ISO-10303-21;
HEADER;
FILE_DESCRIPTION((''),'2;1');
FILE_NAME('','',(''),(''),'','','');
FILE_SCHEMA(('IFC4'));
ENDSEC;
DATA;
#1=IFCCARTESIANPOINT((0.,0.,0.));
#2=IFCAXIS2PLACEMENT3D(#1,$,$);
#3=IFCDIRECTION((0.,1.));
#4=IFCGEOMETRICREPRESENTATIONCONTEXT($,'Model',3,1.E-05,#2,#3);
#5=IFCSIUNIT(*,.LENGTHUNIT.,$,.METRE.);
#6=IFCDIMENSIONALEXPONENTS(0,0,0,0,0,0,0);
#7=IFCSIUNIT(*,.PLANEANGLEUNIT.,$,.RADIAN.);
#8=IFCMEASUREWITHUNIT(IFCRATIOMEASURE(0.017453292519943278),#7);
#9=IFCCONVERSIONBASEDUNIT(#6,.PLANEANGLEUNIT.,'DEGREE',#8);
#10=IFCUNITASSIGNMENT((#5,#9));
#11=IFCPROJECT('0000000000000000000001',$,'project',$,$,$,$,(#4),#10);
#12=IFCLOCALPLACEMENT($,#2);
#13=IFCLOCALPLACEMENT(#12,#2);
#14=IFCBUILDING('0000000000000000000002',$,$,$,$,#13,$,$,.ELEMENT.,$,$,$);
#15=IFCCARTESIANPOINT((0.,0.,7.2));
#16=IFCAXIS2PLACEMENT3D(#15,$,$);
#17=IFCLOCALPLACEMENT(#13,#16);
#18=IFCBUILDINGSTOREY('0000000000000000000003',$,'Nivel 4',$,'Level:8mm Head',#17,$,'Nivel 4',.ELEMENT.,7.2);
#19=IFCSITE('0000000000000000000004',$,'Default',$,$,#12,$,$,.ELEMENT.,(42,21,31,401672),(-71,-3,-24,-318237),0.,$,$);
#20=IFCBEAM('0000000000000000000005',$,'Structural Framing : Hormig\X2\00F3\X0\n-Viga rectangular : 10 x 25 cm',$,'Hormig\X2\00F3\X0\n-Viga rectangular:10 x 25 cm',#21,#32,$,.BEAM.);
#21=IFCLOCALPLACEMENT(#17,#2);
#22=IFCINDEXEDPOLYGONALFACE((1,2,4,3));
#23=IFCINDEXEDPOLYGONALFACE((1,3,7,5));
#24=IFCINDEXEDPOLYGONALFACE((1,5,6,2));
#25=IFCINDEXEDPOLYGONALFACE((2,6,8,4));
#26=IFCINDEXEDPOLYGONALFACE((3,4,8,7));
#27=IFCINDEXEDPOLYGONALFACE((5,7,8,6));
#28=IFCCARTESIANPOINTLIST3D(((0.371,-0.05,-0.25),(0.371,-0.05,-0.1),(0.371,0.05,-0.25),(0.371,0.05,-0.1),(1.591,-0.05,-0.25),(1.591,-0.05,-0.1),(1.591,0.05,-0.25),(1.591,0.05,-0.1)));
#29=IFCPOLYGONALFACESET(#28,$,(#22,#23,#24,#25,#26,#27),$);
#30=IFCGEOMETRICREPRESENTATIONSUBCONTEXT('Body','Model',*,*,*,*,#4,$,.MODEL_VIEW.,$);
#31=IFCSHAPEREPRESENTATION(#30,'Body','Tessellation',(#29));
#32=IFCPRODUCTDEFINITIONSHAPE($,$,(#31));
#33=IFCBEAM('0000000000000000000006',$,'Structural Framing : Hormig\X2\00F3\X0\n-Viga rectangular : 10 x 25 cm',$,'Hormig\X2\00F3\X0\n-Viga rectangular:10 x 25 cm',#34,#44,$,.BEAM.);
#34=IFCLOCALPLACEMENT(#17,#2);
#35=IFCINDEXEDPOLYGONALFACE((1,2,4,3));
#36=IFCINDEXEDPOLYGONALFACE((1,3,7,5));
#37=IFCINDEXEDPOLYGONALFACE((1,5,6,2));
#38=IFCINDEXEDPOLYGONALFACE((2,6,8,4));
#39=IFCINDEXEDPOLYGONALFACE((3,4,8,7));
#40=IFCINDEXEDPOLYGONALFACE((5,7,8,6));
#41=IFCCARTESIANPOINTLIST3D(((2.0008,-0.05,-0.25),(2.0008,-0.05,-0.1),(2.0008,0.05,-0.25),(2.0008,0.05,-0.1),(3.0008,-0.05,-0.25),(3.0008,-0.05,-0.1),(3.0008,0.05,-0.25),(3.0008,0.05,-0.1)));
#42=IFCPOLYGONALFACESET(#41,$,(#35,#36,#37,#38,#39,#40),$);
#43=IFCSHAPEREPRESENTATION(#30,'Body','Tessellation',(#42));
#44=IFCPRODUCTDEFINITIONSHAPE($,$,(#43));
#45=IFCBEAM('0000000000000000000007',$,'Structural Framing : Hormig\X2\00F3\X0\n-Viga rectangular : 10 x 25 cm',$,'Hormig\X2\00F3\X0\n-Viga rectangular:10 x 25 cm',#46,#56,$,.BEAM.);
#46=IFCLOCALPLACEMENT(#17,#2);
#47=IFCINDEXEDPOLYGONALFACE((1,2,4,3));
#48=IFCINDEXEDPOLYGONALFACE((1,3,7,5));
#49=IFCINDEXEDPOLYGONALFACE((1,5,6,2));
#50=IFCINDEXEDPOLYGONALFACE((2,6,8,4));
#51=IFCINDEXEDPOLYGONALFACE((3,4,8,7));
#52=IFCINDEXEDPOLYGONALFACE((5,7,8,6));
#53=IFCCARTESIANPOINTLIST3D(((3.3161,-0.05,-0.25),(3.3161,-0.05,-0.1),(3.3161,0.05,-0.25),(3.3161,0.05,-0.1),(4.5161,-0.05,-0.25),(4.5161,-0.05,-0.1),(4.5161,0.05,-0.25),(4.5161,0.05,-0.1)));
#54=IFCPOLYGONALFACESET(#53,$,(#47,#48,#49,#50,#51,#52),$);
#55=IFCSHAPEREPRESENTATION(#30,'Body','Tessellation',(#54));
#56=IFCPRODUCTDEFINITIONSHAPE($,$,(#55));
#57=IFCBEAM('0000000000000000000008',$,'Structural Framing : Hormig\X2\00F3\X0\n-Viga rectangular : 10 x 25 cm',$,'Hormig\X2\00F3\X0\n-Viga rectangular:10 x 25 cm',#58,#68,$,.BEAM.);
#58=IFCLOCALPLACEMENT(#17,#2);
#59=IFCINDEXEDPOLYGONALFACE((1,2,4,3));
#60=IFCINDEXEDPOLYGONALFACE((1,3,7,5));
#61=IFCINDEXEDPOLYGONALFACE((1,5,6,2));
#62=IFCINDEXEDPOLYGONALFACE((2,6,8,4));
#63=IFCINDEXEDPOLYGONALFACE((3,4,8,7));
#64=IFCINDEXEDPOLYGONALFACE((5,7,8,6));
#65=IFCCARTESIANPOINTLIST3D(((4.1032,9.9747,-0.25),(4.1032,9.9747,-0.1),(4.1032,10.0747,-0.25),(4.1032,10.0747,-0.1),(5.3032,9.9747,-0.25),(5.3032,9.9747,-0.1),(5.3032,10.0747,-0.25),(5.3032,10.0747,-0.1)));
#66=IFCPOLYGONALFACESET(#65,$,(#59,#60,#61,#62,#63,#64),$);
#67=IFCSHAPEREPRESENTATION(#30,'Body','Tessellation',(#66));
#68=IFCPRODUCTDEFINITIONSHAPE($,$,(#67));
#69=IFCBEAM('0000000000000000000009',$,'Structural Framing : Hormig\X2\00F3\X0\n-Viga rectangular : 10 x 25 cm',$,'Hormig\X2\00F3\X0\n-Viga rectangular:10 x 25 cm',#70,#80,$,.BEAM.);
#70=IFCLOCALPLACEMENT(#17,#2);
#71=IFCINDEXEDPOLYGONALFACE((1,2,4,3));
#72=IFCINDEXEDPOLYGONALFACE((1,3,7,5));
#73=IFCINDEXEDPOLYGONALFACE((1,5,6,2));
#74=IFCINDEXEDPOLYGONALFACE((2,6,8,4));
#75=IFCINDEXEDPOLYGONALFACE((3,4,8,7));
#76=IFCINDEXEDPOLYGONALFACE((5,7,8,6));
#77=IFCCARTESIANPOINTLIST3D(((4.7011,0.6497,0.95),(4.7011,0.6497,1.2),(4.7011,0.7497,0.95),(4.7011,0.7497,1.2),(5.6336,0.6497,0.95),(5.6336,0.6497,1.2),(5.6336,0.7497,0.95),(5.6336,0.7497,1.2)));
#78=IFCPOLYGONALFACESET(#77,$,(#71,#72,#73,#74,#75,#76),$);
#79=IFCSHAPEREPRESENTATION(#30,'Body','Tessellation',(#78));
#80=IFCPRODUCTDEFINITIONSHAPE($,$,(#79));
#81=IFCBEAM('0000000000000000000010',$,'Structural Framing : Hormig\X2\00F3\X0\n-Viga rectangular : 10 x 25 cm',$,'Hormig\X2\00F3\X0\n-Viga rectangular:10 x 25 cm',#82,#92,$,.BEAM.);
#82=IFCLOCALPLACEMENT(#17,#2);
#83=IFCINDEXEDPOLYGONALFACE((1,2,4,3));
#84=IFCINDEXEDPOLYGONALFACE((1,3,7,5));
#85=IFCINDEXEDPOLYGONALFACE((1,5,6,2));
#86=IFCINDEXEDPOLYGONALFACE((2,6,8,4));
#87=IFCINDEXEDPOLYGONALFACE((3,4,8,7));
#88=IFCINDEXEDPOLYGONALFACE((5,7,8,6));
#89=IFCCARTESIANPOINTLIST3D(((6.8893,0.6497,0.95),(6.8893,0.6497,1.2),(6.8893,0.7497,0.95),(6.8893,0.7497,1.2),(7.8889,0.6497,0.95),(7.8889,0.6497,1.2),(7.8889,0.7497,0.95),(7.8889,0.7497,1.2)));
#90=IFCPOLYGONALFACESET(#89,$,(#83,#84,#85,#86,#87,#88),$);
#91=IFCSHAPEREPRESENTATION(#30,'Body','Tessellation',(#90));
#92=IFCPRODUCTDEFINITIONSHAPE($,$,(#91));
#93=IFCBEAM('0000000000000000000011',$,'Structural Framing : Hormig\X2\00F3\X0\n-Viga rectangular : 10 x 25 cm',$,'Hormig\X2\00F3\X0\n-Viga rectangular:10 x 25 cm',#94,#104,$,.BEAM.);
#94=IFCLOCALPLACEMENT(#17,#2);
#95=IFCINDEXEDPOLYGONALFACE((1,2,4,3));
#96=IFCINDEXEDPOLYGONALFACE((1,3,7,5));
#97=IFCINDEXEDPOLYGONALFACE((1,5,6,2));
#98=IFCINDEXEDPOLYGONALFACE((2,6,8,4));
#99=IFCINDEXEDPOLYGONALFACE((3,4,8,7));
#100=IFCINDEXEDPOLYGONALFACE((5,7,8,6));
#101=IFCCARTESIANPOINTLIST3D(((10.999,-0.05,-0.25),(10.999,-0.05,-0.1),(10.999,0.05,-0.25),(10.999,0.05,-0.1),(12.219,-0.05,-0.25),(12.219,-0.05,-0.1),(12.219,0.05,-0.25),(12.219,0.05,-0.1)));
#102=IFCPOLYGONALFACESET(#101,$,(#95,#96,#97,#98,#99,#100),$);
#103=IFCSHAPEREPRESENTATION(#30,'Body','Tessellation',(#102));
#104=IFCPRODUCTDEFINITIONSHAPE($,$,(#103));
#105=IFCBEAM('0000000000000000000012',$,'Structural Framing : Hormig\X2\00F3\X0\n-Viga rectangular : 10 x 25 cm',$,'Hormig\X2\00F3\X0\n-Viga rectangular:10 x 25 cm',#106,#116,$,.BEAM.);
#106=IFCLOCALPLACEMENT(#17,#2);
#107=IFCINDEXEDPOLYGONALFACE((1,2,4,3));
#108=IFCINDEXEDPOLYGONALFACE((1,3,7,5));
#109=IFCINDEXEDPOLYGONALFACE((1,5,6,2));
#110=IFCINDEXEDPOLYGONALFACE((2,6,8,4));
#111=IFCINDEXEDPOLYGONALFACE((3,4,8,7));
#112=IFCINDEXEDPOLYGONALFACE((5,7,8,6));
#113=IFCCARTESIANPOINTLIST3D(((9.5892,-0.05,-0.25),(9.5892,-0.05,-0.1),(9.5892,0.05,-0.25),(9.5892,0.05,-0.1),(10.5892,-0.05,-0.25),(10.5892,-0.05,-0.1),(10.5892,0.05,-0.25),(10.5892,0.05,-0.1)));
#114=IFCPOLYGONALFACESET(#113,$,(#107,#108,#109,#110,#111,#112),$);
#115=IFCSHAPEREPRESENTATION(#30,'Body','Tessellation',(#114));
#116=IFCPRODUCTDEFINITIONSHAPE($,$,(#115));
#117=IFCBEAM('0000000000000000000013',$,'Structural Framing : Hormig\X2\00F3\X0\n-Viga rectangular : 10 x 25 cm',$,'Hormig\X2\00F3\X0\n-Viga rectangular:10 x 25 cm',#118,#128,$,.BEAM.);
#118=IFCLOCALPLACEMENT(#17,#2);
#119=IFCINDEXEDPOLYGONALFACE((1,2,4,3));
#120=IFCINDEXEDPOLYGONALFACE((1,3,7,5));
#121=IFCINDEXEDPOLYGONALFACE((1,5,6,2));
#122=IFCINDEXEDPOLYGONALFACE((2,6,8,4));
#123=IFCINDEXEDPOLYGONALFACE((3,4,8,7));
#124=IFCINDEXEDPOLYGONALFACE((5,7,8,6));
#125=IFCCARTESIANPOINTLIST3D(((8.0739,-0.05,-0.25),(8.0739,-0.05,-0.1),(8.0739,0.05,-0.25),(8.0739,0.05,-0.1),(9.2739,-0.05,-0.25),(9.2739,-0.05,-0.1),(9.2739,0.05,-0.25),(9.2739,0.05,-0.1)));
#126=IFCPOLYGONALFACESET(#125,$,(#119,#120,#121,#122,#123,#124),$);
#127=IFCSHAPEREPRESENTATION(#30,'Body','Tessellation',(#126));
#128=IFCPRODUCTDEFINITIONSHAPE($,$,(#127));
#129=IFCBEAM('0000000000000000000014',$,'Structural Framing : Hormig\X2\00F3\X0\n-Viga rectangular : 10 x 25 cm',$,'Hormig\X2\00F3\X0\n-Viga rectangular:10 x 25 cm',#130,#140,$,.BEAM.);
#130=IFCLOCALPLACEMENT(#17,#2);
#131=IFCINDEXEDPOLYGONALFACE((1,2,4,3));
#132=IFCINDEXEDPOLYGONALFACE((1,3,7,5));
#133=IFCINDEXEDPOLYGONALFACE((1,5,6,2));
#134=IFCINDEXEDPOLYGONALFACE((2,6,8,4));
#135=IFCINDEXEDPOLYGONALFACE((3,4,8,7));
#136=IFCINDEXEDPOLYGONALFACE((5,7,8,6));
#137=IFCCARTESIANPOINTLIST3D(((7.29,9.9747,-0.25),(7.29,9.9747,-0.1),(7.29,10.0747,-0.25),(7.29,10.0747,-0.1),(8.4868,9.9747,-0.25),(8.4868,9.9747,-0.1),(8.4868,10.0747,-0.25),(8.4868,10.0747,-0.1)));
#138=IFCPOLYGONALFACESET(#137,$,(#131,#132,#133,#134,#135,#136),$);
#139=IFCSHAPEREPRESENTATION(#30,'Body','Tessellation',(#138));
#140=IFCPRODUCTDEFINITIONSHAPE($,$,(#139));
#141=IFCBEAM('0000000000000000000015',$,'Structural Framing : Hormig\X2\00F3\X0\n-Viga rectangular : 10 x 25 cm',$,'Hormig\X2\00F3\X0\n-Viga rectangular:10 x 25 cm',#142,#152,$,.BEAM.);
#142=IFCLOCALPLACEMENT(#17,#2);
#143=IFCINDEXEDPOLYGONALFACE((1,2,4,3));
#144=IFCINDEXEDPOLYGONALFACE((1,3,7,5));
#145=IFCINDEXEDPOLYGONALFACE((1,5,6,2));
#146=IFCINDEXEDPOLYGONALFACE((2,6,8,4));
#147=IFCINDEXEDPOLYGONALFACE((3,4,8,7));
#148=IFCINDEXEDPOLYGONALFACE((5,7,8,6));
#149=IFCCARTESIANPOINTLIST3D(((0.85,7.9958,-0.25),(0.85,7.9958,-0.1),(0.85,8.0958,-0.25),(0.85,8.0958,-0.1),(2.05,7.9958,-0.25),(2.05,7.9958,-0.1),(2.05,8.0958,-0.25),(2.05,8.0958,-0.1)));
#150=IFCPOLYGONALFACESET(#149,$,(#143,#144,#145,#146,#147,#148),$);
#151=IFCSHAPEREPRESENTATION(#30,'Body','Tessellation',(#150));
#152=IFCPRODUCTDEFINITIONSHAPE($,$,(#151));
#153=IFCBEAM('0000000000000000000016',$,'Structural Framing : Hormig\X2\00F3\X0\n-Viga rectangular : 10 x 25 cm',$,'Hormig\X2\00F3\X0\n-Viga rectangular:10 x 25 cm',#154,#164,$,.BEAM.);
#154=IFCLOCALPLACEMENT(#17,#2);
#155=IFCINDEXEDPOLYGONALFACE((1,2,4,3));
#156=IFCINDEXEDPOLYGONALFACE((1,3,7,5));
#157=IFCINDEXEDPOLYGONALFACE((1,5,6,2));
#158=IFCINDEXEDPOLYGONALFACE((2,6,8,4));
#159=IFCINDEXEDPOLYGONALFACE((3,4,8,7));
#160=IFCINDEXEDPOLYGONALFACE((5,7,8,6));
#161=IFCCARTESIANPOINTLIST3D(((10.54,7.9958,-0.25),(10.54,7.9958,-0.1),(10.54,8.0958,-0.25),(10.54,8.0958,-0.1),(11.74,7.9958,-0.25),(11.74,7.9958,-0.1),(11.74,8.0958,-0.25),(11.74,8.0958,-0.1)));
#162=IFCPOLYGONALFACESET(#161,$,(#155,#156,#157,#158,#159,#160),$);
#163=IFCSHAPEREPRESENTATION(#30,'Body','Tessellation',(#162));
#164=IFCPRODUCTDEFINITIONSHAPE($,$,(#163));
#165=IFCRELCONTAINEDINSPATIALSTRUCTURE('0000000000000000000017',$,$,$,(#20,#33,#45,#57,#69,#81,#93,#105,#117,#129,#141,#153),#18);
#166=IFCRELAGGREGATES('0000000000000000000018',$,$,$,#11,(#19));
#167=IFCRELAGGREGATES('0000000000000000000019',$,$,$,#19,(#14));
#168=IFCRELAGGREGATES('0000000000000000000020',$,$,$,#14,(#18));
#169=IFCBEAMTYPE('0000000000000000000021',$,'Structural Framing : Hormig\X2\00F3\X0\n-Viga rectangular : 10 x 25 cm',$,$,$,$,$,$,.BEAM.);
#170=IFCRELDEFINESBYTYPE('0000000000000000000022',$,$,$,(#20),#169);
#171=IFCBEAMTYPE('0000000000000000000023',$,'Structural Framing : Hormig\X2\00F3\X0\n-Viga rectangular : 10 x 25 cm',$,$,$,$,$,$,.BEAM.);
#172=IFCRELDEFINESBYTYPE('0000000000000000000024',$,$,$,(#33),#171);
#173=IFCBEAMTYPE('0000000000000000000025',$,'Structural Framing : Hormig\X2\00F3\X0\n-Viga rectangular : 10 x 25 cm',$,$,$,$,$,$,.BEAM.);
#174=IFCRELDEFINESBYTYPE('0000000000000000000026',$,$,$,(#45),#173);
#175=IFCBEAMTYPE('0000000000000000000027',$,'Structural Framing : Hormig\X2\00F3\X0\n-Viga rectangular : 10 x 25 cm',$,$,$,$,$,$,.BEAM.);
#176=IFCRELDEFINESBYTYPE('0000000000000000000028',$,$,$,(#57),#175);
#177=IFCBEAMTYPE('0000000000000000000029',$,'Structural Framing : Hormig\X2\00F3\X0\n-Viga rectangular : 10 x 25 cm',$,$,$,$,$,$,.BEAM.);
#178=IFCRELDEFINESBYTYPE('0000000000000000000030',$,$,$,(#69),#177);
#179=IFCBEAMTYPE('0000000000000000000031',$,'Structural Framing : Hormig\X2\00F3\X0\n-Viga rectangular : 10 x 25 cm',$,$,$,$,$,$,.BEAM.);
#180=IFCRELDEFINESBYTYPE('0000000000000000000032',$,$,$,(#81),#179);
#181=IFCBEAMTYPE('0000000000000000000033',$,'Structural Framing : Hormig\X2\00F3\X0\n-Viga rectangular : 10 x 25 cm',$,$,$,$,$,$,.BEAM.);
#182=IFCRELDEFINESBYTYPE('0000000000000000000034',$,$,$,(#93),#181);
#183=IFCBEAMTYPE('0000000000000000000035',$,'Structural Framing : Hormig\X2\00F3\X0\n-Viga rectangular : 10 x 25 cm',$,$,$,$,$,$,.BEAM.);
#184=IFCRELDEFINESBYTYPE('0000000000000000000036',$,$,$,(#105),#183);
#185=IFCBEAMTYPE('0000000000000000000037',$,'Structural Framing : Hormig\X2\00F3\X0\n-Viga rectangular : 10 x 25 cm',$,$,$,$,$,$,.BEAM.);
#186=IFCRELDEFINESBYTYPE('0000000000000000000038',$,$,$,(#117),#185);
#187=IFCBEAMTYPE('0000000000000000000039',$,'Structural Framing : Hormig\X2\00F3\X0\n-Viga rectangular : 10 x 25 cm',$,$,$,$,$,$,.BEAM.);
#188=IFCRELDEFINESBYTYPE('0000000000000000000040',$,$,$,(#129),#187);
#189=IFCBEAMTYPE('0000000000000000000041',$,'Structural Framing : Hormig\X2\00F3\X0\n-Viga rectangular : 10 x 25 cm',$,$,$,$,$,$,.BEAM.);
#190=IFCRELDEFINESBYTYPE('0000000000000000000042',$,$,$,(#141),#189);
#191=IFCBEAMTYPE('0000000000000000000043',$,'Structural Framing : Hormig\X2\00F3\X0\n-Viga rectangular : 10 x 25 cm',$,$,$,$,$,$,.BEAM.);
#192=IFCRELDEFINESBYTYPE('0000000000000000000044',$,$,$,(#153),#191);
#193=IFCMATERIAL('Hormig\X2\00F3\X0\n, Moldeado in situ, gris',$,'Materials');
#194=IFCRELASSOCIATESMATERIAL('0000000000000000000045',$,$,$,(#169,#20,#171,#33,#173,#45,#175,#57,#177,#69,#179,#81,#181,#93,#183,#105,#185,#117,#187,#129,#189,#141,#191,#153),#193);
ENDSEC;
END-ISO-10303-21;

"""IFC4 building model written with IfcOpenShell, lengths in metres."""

from ifc_helpers import new_model, entity, si_unit, converted_unit, direction, frame, origin, place, context, subcontext, project, spatial, indexed_curve, outline, extrude, source, transform, mapped, material, type_object, type_shapes, element, save


model = new_model("IFC4")

# Units and contexts
model_context = context("Model", 3, precision=1e-05, world=origin(), true_north=direction((0.0, 1.0)))
body_context = subcontext(model_context, "Body", "Model", "MODEL_VIEW")
ifc_project = project(units=[si_unit("LENGTHUNIT", "METRE"), converted_unit("PLANEANGLEUNIT", "DEGREE", entity("IfcRatioMeasure", 0.017453292519943278), si_unit("PLANEANGLEUNIT", "RADIAN"), dimensions=[0, 0, 0, 0, 0, 0, 0])], contexts=[model_context])

# Site, building, storey
site_placement = place(None, origin())
site = spatial("IfcSite", under=ifc_project, at=site_placement, Name="Default", CompositionType="ELEMENT", RefLatitude=(42, 21, 31, 401672), RefLongitude=(-71, -3, -24, -318237), RefElevation=0.0)
building_placement = place(site_placement, origin())
building = spatial("IfcBuilding", under=site, at=building_placement, CompositionType="ELEMENT")
storey_placement = place(building_placement, frame((0.0, 0.0, 7.2)))
storey = spatial("IfcBuildingStorey", under=building, at=storey_placement, Name="Nivel 4", ObjectType="Level:8mm Head", LongName="Nivel 4", CompositionType="ELEMENT", Elevation=7.2)

# Beams
ifc_material_1 = material(Name="Hormigón, Moldeado in situ, gris", Category="Materials")
beam_type_1 = type_object("IfcBeamType", Name="Structural Framing : Hormigón-Viga rectangular : 10 x 25 cm", PredefinedType="BEAM", material=ifc_material_1)
shared_shape_1 = source(origin(), body_context, "Body", "SweptSolid", [
    extrude(outline(indexed_curve([(-0.075, -0.05), (0.075, -0.05), (0.075, 0.05), (-0.075, 0.05), (-0.075, -0.05)], self_intersect=False)), frame((0.371, 0.0, 7.025), z_axis=(1.0, 0.0, 0.0), x_axis=(0.0, 0.0, -1.0)), (0.0, 0.0, 1.0), 1.22),
])
type_shapes(beam_type_1, [shared_shape_1])
beam_1_placement = place(storey_placement, frame((0.0, 0.0, -7.2)))
element("IfcBeam", 1, at=beam_1_placement, inside=storey, type_object=beam_type_1, material=ifc_material_1, Name="Structural Framing : Hormigón-Viga rectangular : 10 x 25 cm", ObjectType="Hormigón-Viga rectangular:10 x 25 cm", PredefinedType="BEAM", context=body_context, shape_type="MappedRepresentation", body=[
    mapped(shared_shape_1, transform((0.0, 0.0, 0.0), scale=1.0)),
])
beam_type_2 = type_object("IfcBeamType", Name="Structural Framing : Hormigón-Viga rectangular : 10 x 25 cm", PredefinedType="BEAM", material=ifc_material_1)
shared_shape_2 = source(origin(), body_context, "Body", "SweptSolid", [
    extrude(outline(indexed_curve([(-0.075, -0.05), (0.075, -0.05), (0.075, 0.05), (-0.075, 0.05), (-0.075, -0.05)], self_intersect=False)), frame((2.0008, 0.0, 7.025), z_axis=(1.0, 0.0, 0.0), x_axis=(0.0, 0.0, -1.0)), (0.0, 0.0, 1.0), 1.0),
])
type_shapes(beam_type_2, [shared_shape_2])
beam_2_placement = place(storey_placement, frame((0.0, 0.0, -7.2)))
element("IfcBeam", 2, at=beam_2_placement, inside=storey, type_object=beam_type_2, material=ifc_material_1, Name="Structural Framing : Hormigón-Viga rectangular : 10 x 25 cm", ObjectType="Hormigón-Viga rectangular:10 x 25 cm", PredefinedType="BEAM", context=body_context, shape_type="MappedRepresentation", body=[
    mapped(shared_shape_2, transform((0.0, 0.0, 0.0), scale=1.0)),
])
beam_type_3 = type_object("IfcBeamType", Name="Structural Framing : Hormigón-Viga rectangular : 10 x 25 cm", PredefinedType="BEAM", material=ifc_material_1)
shared_shape_3 = source(origin(), body_context, "Body", "SweptSolid", [
    extrude(outline(indexed_curve([(-0.075, -0.05), (0.075, -0.05), (0.075, 0.05), (-0.075, 0.05), (-0.075, -0.05)], self_intersect=False)), frame((3.3161, 0.0, 7.025), z_axis=(1.0, 0.0, 0.0), x_axis=(0.0, 0.0, -1.0)), (0.0, 0.0, 1.0), 1.2),
])
type_shapes(beam_type_3, [shared_shape_3])
beam_3_placement = place(storey_placement, frame((0.0, 0.0, -7.2)))
element("IfcBeam", 3, at=beam_3_placement, inside=storey, type_object=beam_type_3, material=ifc_material_1, Name="Structural Framing : Hormigón-Viga rectangular : 10 x 25 cm", ObjectType="Hormigón-Viga rectangular:10 x 25 cm", PredefinedType="BEAM", context=body_context, shape_type="MappedRepresentation", body=[
    mapped(shared_shape_3, transform((0.0, 0.0, 0.0), scale=1.0)),
])
beam_type_4 = type_object("IfcBeamType", Name="Structural Framing : Hormigón-Viga rectangular : 10 x 25 cm", PredefinedType="BEAM", material=ifc_material_1)
shared_shape_4 = source(origin(), body_context, "Body", "SweptSolid", [
    extrude(outline(indexed_curve([(-0.075, -0.05), (0.075, -0.05), (0.075, 0.05), (-0.075, 0.05), (-0.075, -0.05)], self_intersect=False)), frame((5.3032, 10.0247, 7.025), z_axis=(-1.0, 0.0, 0.0), x_axis=(0.0, 0.0, -1.0)), (0.0, 0.0, 1.0), 1.2),
])
type_shapes(beam_type_4, [shared_shape_4])
beam_4_placement = place(storey_placement, frame((0.0, 0.0, -7.2)))
element("IfcBeam", 4, at=beam_4_placement, inside=storey, type_object=beam_type_4, material=ifc_material_1, Name="Structural Framing : Hormigón-Viga rectangular : 10 x 25 cm", ObjectType="Hormigón-Viga rectangular:10 x 25 cm", PredefinedType="BEAM", context=body_context, shape_type="MappedRepresentation", body=[
    mapped(shared_shape_4, transform((0.0, 0.0, 0.0), scale=1.0)),
])
beam_type_5 = type_object("IfcBeamType", Name="Structural Framing : Hormigón-Viga rectangular : 10 x 25 cm", PredefinedType="BEAM", material=ifc_material_1)
shared_shape_5 = source(origin(), body_context, "Body", "SweptSolid", [
    extrude(outline(indexed_curve([(-0.125, -0.05), (0.125, -0.05), (0.125, 0.05), (-0.125, 0.05), (-0.125, -0.05)], self_intersect=False)), frame((5.6336, 0.6997, 8.275), z_axis=(-1.0, 0.0, 0.0), x_axis=(0.0, 0.0, -1.0)), (0.0, 0.0, 1.0), 0.9325),
])
type_shapes(beam_type_5, [shared_shape_5])
beam_5_placement = place(storey_placement, frame((0.0, 0.0, -7.2)))
element("IfcBeam", 5, at=beam_5_placement, inside=storey, type_object=beam_type_5, material=ifc_material_1, Name="Structural Framing : Hormigón-Viga rectangular : 10 x 25 cm", ObjectType="Hormigón-Viga rectangular:10 x 25 cm", PredefinedType="BEAM", context=body_context, shape_type="MappedRepresentation", body=[
    mapped(shared_shape_5, transform((0.0, 0.0, 0.0), scale=1.0)),
])
beam_type_6 = type_object("IfcBeamType", Name="Structural Framing : Hormigón-Viga rectangular : 10 x 25 cm", PredefinedType="BEAM", material=ifc_material_1)
shared_shape_6 = source(origin(), body_context, "Body", "SweptSolid", [
    extrude(outline(indexed_curve([(-0.125, -0.05), (0.125, -0.05), (0.125, 0.05), (-0.125, 0.05), (-0.125, -0.05)], self_intersect=False)), frame((7.8889, 0.6997, 8.275), z_axis=(-1.0, 0.0, 0.0), x_axis=(0.0, 0.0, -1.0)), (0.0, 0.0, 1.0), 0.9996),
])
type_shapes(beam_type_6, [shared_shape_6])
beam_6_placement = place(storey_placement, frame((0.0, 0.0, -7.2)))
element("IfcBeam", 6, at=beam_6_placement, inside=storey, type_object=beam_type_6, material=ifc_material_1, Name="Structural Framing : Hormigón-Viga rectangular : 10 x 25 cm", ObjectType="Hormigón-Viga rectangular:10 x 25 cm", PredefinedType="BEAM", context=body_context, shape_type="MappedRepresentation", body=[
    mapped(shared_shape_6, transform((0.0, 0.0, 0.0), scale=1.0)),
])
beam_type_7 = type_object("IfcBeamType", Name="Structural Framing : Hormigón-Viga rectangular : 10 x 25 cm", PredefinedType="BEAM", material=ifc_material_1)
shared_shape_7 = source(origin(), body_context, "Body", "SweptSolid", [
    extrude(outline(indexed_curve([(-0.075, -0.05), (0.075, -0.05), (0.075, 0.05), (-0.075, 0.05), (-0.075, -0.05)], self_intersect=False)), frame((12.219, 0.0, 7.025), z_axis=(-1.0, 0.0, 0.0), x_axis=(0.0, 0.0, -1.0)), (0.0, 0.0, 1.0), 1.22),
])
type_shapes(beam_type_7, [shared_shape_7])
beam_7_placement = place(storey_placement, frame((0.0, 0.0, -7.2)))
element("IfcBeam", 7, at=beam_7_placement, inside=storey, type_object=beam_type_7, material=ifc_material_1, Name="Structural Framing : Hormigón-Viga rectangular : 10 x 25 cm", ObjectType="Hormigón-Viga rectangular:10 x 25 cm", PredefinedType="BEAM", context=body_context, shape_type="MappedRepresentation", body=[
    mapped(shared_shape_7, transform((0.0, 0.0, 0.0), scale=1.0)),
])
beam_type_8 = type_object("IfcBeamType", Name="Structural Framing : Hormigón-Viga rectangular : 10 x 25 cm", PredefinedType="BEAM", material=ifc_material_1)
shared_shape_8 = source(origin(), body_context, "Body", "SweptSolid", [
    extrude(outline(indexed_curve([(-0.075, -0.05), (0.075, -0.05), (0.075, 0.05), (-0.075, 0.05), (-0.075, -0.05)], self_intersect=False)), frame((10.5892, 0.0, 7.025), z_axis=(-1.0, 0.0, 0.0), x_axis=(0.0, 0.0, -1.0)), (0.0, 0.0, 1.0), 1.0),
])
type_shapes(beam_type_8, [shared_shape_8])
beam_8_placement = place(storey_placement, frame((0.0, 0.0, -7.2)))
element("IfcBeam", 8, at=beam_8_placement, inside=storey, type_object=beam_type_8, material=ifc_material_1, Name="Structural Framing : Hormigón-Viga rectangular : 10 x 25 cm", ObjectType="Hormigón-Viga rectangular:10 x 25 cm", PredefinedType="BEAM", context=body_context, shape_type="MappedRepresentation", body=[
    mapped(shared_shape_8, transform((0.0, 0.0, 0.0), scale=1.0)),
])
beam_type_9 = type_object("IfcBeamType", Name="Structural Framing : Hormigón-Viga rectangular : 10 x 25 cm", PredefinedType="BEAM", material=ifc_material_1)
shared_shape_9 = source(origin(), body_context, "Body", "SweptSolid", [
    extrude(outline(indexed_curve([(-0.075, -0.05), (0.075, -0.05), (0.075, 0.05), (-0.075, 0.05), (-0.075, -0.05)], self_intersect=False)), frame((9.2739, 0.0, 7.025), z_axis=(-1.0, 0.0, 0.0), x_axis=(0.0, 0.0, -1.0)), (0.0, 0.0, 1.0), 1.2),
])
type_shapes(beam_type_9, [shared_shape_9])
beam_9_placement = place(storey_placement, frame((0.0, 0.0, -7.2)))
element("IfcBeam", 9, at=beam_9_placement, inside=storey, type_object=beam_type_9, material=ifc_material_1, Name="Structural Framing : Hormigón-Viga rectangular : 10 x 25 cm", ObjectType="Hormigón-Viga rectangular:10 x 25 cm", PredefinedType="BEAM", context=body_context, shape_type="MappedRepresentation", body=[
    mapped(shared_shape_9, transform((0.0, 0.0, 0.0), scale=1.0)),
])
beam_type_10 = type_object("IfcBeamType", Name="Structural Framing : Hormigón-Viga rectangular : 10 x 25 cm", PredefinedType="BEAM", material=ifc_material_1)
shared_shape_10 = source(origin(), body_context, "Body", "SweptSolid", [
    extrude(outline(indexed_curve([(-0.075, -0.05), (0.075, -0.05), (0.075, 0.05), (-0.075, 0.05), (-0.075, -0.05)], self_intersect=False)), frame((7.29, 10.0247, 7.025), z_axis=(1.0, 0.0, 0.0), x_axis=(0.0, 0.0, -1.0)), (0.0, 0.0, 1.0), 1.1968),
])
type_shapes(beam_type_10, [shared_shape_10])
beam_10_placement = place(storey_placement, frame((0.0, 0.0, -7.2)))
element("IfcBeam", 10, at=beam_10_placement, inside=storey, type_object=beam_type_10, material=ifc_material_1, Name="Structural Framing : Hormigón-Viga rectangular : 10 x 25 cm", ObjectType="Hormigón-Viga rectangular:10 x 25 cm", PredefinedType="BEAM", context=body_context, shape_type="MappedRepresentation", body=[
    mapped(shared_shape_10, transform((0.0, 0.0, 0.0), scale=1.0)),
])
beam_type_11 = type_object("IfcBeamType", Name="Structural Framing : Hormigón-Viga rectangular : 10 x 25 cm", PredefinedType="BEAM", material=ifc_material_1)
shared_shape_11 = source(origin(), body_context, "Body", "SweptSolid", [
    extrude(outline(indexed_curve([(-0.075, -0.05), (0.075, -0.05), (0.075, 0.05), (-0.075, 0.05), (-0.075, -0.05)], self_intersect=False)), frame((2.05, 8.0458, 7.025), z_axis=(-1.0, 0.0, 0.0), x_axis=(0.0, 0.0, -1.0)), (0.0, 0.0, 1.0), 1.2),
])
type_shapes(beam_type_11, [shared_shape_11])
beam_11_placement = place(storey_placement, frame((0.0, 0.0, -7.2)))
element("IfcBeam", 11, at=beam_11_placement, inside=storey, type_object=beam_type_11, material=ifc_material_1, Name="Structural Framing : Hormigón-Viga rectangular : 10 x 25 cm", ObjectType="Hormigón-Viga rectangular:10 x 25 cm", PredefinedType="BEAM", context=body_context, shape_type="MappedRepresentation", body=[
    mapped(shared_shape_11, transform((0.0, 0.0, 0.0), scale=1.0)),
])
beam_type_12 = type_object("IfcBeamType", Name="Structural Framing : Hormigón-Viga rectangular : 10 x 25 cm", PredefinedType="BEAM", material=ifc_material_1)
shared_shape_12 = source(origin(), body_context, "Body", "SweptSolid", [
    extrude(outline(indexed_curve([(-0.075, -0.05), (0.075, -0.05), (0.075, 0.05), (-0.075, 0.05), (-0.075, -0.05)], self_intersect=False)), frame((10.54, 8.0458, 7.025), z_axis=(1.0, 0.0, 0.0), x_axis=(0.0, 0.0, -1.0)), (0.0, 0.0, 1.0), 1.2),
])
type_shapes(beam_type_12, [shared_shape_12])
beam_12_placement = place(storey_placement, frame((0.0, 0.0, -7.2)))
element("IfcBeam", 12, at=beam_12_placement, inside=storey, type_object=beam_type_12, material=ifc_material_1, Name="Structural Framing : Hormigón-Viga rectangular : 10 x 25 cm", ObjectType="Hormigón-Viga rectangular:10 x 25 cm", PredefinedType="BEAM", context=body_context, shape_type="MappedRepresentation", body=[
    mapped(shared_shape_12, transform((0.0, 0.0, 0.0), scale=1.0)),
])

save(model, "model.ifc")
